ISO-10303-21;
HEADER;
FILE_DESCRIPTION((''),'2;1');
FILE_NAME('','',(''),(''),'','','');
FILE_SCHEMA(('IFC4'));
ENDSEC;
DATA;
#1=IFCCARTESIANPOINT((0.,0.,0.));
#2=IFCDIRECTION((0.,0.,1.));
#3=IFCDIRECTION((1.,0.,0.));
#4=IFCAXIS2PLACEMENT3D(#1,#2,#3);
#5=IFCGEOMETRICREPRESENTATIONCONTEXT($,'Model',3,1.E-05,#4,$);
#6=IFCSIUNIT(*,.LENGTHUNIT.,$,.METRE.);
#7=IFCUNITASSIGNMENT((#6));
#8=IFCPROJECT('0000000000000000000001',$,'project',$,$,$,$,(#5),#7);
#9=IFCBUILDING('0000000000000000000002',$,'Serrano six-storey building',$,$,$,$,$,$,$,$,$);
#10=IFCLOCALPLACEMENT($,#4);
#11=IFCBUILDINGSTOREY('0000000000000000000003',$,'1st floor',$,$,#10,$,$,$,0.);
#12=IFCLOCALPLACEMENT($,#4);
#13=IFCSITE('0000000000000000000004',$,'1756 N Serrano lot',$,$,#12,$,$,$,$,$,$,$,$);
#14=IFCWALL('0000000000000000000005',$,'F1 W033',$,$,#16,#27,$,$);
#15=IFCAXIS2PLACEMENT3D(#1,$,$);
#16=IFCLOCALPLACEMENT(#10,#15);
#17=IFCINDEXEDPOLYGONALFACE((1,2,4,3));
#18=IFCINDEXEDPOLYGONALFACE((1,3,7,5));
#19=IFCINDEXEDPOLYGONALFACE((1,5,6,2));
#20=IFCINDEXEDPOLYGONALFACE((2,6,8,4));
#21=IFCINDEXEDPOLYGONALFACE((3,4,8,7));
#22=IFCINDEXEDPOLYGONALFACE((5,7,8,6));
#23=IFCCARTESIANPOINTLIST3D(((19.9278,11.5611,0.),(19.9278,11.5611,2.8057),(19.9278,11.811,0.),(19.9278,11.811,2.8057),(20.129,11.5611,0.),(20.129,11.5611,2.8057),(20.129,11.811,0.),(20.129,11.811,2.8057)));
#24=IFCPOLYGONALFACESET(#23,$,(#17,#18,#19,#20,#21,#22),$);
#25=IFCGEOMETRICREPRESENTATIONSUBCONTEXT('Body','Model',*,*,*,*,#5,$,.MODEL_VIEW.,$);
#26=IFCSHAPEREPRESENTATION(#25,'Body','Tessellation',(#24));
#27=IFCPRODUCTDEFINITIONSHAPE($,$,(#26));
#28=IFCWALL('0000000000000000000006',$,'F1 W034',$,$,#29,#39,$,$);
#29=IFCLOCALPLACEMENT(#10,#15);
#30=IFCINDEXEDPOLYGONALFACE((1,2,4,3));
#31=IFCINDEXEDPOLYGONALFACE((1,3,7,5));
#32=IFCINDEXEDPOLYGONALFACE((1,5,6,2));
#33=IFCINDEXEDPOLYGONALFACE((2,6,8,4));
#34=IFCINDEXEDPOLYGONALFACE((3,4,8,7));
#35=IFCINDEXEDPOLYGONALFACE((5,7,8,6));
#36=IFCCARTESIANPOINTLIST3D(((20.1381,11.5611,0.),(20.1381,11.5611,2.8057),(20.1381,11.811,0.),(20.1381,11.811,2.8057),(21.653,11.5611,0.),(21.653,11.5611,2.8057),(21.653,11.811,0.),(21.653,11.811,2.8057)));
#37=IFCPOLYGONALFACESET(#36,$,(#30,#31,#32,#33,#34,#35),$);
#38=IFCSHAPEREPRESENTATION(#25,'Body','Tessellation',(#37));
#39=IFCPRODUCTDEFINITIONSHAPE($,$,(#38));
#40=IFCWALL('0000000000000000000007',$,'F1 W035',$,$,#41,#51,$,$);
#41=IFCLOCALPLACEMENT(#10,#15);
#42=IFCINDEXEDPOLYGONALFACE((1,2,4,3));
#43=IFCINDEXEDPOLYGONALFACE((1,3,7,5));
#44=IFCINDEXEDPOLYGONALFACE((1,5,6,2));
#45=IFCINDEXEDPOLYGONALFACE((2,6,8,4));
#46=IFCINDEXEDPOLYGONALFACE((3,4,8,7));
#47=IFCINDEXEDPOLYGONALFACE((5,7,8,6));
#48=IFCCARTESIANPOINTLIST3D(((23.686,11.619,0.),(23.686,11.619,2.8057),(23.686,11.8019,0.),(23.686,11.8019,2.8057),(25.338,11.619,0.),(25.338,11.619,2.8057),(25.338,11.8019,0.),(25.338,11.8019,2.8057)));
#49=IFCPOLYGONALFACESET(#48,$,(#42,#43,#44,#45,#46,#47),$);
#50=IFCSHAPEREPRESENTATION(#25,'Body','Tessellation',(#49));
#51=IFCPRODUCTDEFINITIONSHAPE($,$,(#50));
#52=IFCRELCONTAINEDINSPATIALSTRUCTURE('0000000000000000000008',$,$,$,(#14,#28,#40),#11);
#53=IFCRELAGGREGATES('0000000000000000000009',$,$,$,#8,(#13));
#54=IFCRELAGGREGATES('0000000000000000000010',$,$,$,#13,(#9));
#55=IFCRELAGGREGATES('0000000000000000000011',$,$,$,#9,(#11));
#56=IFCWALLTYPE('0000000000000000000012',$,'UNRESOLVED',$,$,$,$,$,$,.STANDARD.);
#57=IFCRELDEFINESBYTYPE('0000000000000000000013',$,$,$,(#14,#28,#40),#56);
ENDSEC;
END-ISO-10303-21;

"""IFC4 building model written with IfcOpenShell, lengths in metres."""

from ifc_helpers import new_model, si_unit, origin, origin_with_axes, place, context, subcontext, project, spatial, polyline, outline, extrude, type_object, element, save


model = new_model("IFC4")

# Units and contexts
model_context = context("Model", 3, precision=1e-05, world=origin_with_axes())
body_context = subcontext(model_context, "Body", "Model", "MODEL_VIEW")
ifc_project = project(units=[si_unit("LENGTHUNIT", "METRE")], contexts=[model_context])

# Site, building, storey
site_placement = place(None, origin_with_axes())
site = spatial("IfcSite", under=ifc_project, at=site_placement, Name="1756 N Serrano lot")
building = spatial("IfcBuilding", under=site, Name="Serrano six-storey building")
storey_placement = place(None, origin_with_axes())
storey = spatial("IfcBuildingStorey", under=building, at=storey_placement, Name="1st floor", Elevation=0.0)

# Walls
wall_type = type_object("IfcWallType", Name="UNRESOLVED", PredefinedType="STANDARD")
wall_1_placement = place(storey_placement, origin_with_axes())
element("IfcWall", 1, at=wall_1_placement, inside=storey, type_object=wall_type, Name="F1 W033", context=body_context, shape_type="SweptSolid", body=[
    extrude(outline(polyline([(20.129, 11.811), (20.129, 11.5611), (19.9278, 11.5611), (19.9278, 11.811), (20.129, 11.811)])), origin(), (0.0, 0.0, 1.0), 2.8057),
])
wall_2_placement = place(storey_placement, origin_with_axes())
element("IfcWall", 2, at=wall_2_placement, inside=storey, type_object=wall_type, Name="F1 W034", context=body_context, shape_type="SweptSolid", body=[
    extrude(outline(polyline([(21.653, 11.811), (21.653, 11.5611), (20.1381, 11.5611), (20.1381, 11.811), (21.653, 11.811)])), origin(), (0.0, 0.0, 1.0), 2.8057),
])
wall_3_placement = place(storey_placement, origin_with_axes())
element("IfcWall", 3, at=wall_3_placement, inside=storey, type_object=wall_type, Name="F1 W035", context=body_context, shape_type="SweptSolid", body=[
    extrude(outline(polyline([(25.338, 11.8019), (25.338, 11.619), (23.686, 11.619), (23.686, 11.8019), (25.338, 11.8019)])), origin(), (0.0, 0.0, 1.0), 2.8057),
])

save(model, "model.ifc")
